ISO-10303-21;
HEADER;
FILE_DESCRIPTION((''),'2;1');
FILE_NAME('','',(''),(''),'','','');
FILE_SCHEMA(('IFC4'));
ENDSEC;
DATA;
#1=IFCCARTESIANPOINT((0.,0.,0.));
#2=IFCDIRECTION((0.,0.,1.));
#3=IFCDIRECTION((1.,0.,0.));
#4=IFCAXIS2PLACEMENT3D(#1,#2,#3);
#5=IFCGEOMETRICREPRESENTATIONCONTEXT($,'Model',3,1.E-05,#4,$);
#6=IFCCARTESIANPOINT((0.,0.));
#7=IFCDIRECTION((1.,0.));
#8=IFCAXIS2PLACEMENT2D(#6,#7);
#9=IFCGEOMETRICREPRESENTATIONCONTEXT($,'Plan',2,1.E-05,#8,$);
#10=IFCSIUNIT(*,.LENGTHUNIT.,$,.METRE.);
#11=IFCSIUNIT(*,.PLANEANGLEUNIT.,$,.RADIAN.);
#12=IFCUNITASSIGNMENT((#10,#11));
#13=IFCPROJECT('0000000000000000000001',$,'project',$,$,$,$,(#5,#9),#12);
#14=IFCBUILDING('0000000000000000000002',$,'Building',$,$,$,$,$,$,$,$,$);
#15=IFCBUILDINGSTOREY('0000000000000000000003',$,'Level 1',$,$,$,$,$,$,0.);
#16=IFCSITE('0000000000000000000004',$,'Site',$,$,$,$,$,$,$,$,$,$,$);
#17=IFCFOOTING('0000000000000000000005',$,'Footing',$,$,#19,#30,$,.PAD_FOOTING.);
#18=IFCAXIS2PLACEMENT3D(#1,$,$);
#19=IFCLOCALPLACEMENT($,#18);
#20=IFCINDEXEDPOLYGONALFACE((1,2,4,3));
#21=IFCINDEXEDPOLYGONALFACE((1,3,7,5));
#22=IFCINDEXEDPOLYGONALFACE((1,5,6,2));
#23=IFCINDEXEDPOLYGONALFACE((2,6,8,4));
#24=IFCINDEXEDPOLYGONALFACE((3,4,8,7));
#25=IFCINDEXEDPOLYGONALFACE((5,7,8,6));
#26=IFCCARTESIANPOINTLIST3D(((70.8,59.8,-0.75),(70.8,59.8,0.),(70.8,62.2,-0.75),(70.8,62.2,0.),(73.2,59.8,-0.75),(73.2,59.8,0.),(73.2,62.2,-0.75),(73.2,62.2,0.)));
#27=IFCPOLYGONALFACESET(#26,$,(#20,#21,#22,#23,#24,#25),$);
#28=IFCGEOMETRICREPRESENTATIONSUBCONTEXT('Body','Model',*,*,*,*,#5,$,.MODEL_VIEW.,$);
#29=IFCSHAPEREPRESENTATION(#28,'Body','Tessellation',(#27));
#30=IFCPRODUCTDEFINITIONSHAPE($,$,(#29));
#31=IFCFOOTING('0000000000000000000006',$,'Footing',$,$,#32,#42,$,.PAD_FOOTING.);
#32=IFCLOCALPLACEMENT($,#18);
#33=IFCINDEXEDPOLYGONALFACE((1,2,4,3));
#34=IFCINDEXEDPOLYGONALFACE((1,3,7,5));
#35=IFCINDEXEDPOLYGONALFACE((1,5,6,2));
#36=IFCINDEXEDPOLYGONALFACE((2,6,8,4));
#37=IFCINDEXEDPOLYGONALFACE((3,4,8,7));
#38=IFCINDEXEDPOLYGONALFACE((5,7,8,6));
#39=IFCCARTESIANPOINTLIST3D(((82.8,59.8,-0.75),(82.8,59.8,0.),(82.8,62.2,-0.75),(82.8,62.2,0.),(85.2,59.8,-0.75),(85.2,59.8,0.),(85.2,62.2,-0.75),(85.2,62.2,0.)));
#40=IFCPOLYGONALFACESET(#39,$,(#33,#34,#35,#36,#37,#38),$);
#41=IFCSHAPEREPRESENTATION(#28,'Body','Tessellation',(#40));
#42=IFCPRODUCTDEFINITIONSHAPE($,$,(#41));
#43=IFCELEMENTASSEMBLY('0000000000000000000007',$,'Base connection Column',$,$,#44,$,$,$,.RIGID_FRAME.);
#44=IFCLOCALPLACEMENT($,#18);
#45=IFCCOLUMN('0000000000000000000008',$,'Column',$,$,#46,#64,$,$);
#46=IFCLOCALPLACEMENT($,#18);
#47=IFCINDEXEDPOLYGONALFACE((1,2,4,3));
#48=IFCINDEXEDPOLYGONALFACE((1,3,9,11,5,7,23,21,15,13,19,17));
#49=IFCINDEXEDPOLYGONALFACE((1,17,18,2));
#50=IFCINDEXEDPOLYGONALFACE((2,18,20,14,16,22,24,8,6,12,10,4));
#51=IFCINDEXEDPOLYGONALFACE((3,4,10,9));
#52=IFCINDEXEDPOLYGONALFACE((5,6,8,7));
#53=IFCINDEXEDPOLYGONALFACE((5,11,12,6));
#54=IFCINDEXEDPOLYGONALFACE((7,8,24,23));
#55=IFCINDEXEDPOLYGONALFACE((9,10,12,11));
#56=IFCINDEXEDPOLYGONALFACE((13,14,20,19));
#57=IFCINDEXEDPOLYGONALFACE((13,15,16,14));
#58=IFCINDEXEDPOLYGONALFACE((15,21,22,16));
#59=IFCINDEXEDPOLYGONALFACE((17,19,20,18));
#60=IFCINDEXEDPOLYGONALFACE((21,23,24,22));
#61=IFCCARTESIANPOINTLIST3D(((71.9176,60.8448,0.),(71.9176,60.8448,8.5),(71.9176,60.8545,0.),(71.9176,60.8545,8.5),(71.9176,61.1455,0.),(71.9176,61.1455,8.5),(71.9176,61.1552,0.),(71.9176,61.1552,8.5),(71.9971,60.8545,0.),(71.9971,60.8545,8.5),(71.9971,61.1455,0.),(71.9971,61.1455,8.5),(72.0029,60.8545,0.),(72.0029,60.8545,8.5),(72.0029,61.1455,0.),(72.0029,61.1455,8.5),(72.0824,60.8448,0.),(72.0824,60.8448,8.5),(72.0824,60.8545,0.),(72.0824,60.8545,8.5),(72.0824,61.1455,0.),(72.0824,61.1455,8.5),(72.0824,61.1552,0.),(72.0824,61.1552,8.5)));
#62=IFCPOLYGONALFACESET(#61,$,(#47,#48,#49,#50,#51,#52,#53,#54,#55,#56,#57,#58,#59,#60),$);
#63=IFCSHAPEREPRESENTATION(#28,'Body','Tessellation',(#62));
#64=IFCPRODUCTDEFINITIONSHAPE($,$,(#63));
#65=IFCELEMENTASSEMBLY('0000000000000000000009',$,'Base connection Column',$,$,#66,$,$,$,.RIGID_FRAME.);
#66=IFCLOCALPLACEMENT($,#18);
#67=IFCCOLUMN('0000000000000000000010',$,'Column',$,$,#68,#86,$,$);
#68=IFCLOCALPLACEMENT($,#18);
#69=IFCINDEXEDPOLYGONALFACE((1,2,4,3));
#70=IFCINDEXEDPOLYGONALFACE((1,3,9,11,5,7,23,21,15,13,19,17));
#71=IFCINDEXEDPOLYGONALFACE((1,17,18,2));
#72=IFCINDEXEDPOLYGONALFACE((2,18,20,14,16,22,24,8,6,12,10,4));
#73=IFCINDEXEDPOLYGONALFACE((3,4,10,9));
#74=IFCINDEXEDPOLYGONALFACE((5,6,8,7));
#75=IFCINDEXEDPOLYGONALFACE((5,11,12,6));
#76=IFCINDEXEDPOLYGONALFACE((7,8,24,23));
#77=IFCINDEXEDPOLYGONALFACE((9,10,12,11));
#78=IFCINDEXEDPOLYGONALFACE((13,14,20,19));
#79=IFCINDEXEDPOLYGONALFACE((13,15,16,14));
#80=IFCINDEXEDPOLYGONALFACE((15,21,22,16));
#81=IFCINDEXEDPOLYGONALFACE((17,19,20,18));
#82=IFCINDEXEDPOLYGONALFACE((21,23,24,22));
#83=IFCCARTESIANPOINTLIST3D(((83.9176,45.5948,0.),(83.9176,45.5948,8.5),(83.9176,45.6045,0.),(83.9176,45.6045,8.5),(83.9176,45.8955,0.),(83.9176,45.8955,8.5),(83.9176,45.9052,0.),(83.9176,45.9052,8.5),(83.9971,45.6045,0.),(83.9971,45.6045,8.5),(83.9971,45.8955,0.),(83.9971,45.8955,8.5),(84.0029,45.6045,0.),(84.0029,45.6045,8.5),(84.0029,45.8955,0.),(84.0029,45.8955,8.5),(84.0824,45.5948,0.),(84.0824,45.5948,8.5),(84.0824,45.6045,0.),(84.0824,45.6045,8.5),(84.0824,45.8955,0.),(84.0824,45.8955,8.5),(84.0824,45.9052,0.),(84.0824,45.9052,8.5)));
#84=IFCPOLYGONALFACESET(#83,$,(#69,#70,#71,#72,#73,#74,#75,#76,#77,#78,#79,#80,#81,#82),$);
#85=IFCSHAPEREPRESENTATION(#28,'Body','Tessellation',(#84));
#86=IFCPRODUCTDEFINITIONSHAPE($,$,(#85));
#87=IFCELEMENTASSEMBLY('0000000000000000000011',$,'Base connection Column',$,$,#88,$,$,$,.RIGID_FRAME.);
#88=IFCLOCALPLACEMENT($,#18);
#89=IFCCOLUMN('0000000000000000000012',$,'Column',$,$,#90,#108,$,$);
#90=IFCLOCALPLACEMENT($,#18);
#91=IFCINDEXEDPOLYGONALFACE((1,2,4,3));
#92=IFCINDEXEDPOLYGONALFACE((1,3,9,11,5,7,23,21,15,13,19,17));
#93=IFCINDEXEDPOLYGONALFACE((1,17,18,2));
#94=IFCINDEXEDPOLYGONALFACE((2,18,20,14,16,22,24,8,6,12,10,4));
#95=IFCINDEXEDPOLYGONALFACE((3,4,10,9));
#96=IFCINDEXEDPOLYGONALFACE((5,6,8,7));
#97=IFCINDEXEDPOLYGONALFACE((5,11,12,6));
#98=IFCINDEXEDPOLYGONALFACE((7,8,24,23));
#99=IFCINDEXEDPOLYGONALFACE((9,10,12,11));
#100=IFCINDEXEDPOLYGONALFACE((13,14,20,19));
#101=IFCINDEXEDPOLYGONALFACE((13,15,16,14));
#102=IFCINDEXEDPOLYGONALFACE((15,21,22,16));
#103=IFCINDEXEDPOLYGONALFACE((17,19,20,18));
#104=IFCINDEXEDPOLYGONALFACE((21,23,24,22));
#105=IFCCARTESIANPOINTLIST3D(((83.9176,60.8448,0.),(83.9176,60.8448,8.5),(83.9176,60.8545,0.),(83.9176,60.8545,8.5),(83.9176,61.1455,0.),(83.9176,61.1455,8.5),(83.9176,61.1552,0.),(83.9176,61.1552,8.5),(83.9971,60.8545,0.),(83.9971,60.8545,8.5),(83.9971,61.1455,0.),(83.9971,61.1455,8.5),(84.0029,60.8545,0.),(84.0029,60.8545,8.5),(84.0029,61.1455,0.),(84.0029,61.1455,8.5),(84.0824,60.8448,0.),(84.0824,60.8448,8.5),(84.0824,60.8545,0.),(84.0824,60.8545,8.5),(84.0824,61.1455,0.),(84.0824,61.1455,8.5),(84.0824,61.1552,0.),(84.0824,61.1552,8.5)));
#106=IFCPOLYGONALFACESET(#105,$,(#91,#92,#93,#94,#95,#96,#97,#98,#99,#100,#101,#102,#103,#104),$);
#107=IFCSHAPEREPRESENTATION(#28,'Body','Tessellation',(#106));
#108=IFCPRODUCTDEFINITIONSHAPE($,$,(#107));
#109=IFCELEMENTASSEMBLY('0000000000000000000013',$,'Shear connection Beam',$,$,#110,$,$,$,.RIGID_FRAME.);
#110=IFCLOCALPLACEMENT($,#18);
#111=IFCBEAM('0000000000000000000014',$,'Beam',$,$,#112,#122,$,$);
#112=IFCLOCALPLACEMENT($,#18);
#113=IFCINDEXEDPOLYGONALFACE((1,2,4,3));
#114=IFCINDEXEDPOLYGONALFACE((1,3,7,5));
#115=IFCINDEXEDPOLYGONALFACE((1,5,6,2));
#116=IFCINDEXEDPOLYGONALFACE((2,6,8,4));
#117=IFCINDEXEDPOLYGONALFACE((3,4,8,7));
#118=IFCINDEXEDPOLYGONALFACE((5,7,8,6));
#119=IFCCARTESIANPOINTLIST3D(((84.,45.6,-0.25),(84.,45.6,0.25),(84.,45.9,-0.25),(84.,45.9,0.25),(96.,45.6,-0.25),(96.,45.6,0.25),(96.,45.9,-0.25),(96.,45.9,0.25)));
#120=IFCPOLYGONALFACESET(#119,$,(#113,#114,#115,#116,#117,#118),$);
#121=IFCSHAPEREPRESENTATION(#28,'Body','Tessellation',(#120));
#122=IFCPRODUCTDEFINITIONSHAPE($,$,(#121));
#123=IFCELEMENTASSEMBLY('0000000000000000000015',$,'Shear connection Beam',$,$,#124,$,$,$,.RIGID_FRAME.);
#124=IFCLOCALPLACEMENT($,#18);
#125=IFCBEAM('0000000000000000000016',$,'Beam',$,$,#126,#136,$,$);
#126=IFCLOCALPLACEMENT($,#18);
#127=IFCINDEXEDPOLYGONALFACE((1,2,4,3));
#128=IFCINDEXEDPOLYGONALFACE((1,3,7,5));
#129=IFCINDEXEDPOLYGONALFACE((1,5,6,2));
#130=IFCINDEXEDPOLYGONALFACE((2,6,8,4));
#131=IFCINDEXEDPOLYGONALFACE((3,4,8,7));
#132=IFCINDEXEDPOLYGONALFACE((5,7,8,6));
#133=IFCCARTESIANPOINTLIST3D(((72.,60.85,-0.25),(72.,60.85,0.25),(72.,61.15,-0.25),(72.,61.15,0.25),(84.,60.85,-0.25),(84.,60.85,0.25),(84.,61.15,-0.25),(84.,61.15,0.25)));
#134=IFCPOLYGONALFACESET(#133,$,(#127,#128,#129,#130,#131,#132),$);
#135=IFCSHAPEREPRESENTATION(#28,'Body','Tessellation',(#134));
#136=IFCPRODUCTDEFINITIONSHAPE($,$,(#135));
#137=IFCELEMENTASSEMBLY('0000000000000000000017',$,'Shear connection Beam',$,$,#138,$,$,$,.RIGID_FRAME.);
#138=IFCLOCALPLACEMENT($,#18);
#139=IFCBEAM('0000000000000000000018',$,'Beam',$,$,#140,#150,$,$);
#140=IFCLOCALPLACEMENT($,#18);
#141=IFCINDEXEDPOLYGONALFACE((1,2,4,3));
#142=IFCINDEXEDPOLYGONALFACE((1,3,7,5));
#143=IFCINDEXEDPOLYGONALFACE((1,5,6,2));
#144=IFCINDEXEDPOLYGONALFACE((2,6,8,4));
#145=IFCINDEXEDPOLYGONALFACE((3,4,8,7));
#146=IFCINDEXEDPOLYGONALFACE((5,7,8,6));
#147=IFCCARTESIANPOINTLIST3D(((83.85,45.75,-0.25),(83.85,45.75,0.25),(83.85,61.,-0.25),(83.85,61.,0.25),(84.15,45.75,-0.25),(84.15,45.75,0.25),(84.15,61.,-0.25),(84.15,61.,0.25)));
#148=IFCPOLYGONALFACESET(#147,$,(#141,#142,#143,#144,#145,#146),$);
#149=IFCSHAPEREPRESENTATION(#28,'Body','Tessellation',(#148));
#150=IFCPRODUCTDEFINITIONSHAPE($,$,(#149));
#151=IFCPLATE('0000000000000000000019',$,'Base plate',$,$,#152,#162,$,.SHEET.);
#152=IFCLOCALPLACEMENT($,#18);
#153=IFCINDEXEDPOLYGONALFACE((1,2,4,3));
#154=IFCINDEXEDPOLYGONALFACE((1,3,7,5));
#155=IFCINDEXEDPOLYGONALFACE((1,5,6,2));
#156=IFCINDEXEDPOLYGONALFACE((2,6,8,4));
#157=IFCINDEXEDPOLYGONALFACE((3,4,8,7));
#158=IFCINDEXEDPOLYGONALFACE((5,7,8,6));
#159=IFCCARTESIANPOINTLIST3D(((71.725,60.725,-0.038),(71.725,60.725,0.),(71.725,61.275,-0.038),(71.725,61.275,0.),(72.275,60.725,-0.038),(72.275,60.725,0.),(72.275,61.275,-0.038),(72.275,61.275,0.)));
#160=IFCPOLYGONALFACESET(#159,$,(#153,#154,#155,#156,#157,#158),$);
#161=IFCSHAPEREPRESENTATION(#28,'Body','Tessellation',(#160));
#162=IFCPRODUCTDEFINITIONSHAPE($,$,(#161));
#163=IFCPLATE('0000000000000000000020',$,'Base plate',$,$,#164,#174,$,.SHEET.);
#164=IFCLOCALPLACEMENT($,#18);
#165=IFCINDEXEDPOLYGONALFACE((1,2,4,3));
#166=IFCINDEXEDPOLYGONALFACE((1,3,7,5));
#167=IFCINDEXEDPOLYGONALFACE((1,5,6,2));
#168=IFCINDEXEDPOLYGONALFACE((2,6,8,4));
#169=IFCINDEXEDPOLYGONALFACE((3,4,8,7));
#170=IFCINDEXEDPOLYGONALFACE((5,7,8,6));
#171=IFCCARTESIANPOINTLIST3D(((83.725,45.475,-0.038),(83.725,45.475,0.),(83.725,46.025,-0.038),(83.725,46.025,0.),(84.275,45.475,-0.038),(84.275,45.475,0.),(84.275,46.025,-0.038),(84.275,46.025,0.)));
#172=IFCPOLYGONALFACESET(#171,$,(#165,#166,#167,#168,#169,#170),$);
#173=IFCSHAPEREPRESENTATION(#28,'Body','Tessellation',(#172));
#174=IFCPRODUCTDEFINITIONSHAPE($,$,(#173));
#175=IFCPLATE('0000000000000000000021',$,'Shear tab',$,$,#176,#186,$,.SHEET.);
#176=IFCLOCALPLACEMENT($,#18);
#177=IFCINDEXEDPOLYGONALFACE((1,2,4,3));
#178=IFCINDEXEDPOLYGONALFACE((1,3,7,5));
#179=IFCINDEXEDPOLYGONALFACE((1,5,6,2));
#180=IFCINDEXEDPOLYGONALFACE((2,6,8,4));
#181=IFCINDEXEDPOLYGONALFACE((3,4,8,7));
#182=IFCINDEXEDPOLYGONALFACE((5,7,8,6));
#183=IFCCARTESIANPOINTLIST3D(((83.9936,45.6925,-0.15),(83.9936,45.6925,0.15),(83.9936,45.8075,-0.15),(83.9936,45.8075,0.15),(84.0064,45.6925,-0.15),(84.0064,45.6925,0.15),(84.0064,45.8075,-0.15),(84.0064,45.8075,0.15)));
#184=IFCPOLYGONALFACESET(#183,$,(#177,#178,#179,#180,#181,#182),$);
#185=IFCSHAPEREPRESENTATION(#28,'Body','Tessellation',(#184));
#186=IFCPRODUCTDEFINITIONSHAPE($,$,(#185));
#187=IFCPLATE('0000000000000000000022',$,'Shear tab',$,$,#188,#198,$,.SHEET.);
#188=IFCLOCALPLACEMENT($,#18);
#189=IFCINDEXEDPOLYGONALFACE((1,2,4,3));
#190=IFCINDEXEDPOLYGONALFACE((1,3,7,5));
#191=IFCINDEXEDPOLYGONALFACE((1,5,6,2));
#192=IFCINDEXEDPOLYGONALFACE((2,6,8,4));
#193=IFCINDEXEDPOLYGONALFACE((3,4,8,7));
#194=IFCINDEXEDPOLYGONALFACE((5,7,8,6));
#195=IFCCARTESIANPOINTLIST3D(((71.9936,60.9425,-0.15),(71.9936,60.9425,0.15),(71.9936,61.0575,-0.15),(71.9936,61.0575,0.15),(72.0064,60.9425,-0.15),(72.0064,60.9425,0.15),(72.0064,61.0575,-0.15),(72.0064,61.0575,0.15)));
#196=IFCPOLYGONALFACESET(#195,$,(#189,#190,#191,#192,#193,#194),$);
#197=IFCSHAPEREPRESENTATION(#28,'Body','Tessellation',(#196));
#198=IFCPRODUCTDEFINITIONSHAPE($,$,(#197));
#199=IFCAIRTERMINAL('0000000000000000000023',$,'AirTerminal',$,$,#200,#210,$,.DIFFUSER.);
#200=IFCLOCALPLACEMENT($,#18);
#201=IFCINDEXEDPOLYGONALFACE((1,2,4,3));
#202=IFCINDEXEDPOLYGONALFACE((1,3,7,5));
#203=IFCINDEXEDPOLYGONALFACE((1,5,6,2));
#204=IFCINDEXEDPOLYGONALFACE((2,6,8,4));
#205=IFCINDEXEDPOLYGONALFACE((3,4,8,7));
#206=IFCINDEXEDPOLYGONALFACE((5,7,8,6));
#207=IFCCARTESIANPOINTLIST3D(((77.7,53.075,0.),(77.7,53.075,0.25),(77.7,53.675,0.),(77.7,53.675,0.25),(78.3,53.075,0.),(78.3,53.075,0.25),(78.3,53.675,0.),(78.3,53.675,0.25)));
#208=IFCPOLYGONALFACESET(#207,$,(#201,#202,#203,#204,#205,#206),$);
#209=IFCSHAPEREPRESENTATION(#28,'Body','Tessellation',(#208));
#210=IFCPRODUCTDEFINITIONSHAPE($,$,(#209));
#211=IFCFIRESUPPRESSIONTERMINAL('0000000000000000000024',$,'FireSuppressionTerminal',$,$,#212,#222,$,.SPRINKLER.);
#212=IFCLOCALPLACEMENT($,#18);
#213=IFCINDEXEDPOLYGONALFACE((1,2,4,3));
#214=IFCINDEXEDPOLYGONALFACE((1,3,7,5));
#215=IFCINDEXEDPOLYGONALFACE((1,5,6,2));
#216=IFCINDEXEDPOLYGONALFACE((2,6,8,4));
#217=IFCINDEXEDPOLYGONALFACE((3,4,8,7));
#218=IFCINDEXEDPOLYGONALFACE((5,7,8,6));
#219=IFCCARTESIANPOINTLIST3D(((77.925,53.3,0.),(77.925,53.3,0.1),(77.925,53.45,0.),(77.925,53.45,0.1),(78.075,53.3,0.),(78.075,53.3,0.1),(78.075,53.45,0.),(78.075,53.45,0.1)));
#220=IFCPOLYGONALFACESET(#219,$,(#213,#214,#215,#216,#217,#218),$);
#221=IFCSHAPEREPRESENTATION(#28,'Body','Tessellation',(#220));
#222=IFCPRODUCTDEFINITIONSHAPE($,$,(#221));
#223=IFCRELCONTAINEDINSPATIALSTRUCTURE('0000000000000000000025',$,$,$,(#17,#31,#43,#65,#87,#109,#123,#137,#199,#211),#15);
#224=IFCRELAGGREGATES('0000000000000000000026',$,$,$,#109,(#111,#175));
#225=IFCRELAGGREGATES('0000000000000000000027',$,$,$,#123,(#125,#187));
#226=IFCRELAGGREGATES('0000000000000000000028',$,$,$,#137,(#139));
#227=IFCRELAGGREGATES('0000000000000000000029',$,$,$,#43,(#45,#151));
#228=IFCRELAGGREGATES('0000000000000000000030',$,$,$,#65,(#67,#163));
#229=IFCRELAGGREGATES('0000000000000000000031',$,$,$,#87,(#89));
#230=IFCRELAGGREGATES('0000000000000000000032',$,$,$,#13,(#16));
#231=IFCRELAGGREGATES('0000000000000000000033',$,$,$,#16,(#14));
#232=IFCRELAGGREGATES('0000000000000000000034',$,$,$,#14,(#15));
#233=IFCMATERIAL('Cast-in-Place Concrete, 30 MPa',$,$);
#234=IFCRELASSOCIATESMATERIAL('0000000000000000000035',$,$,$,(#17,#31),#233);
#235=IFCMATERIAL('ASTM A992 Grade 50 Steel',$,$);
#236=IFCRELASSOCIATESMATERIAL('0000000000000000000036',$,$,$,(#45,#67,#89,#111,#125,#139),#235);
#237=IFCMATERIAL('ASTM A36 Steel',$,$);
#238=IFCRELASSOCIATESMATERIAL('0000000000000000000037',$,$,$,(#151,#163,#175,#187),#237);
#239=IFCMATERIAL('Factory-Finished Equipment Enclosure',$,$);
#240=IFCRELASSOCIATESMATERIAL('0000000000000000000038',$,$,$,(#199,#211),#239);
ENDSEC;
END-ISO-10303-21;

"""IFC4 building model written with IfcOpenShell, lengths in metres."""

from ifc_helpers import new_model, si_unit, frame, origin_with_axes, origin_2d_with_axis, place, context, subcontext, project, spatial, rectangle, i_section, extrude, material, element, aggregate, save


model = new_model("IFC4")

# Units and contexts
model_context = context("Model", 3, precision=1e-05, world=origin_with_axes())
plan_context = context("Plan", 2, precision=1e-05, world=origin_2d_with_axis())
body_context = subcontext(model_context, "Body", "Model", "MODEL_VIEW")
ifc_project = project(units=[si_unit("LENGTHUNIT", "METRE"), si_unit("PLANEANGLEUNIT", "RADIAN")], contexts=[model_context, plan_context])

# Site, building, storey
site = spatial("IfcSite", under=ifc_project, Name="Site")
building = spatial("IfcBuilding", under=site, Name="Building")
storey = spatial("IfcBuildingStorey", under=building, Name="Level 1", Elevation=0.0)

# Footings
ifc_material_1 = material(Name="Cast-in-Place Concrete, 30 MPa")
for number, where, z_axis, x_axis, name in (
    (1, (72.0, 61.0, -0.75), (0.0, 0.0, 1.0), (1.0, 0.0, 0.0), "Footing"),
    (2, (84.0, 61.0, -0.75), (0.0, 0.0, 1.0), (1.0, 0.0, 0.0), "Footing"),
):
    element("IfcFooting", number, at=place(None, frame(where, z_axis=z_axis, x_axis=x_axis)), inside=storey, material=ifc_material_1, Name=name, PredefinedType="PAD_FOOTING", context=body_context, shape_type="SweptSolid", body=[
        extrude(rectangle(XDim=2.4, YDim=2.4, at=origin_2d_with_axis()), origin_with_axes(), (0.0, 0.0, 1.0), 0.75),
    ])

# Element assemblies, columns
assembly_1 = element("IfcElementAssembly", 3, inside=storey, Name="Base connection Column", PredefinedType="RIGID_FRAME")
ifc_material_2 = material(Name="ASTM A992 Grade 50 Steel")
column_1_placement = place(None, frame((72.0, 61.0, 0.0), z_axis=(0.0, 0.0, 1.0), x_axis=(1.0, 0.0, 0.0)))
column_1 = element("IfcColumn", 4, at=column_1_placement, material=ifc_material_2, Name="Column", context=body_context, shape_type="SweptSolid", body=[
    extrude(i_section(OverallWidth=0.1648, OverallDepth=0.3104, WebThickness=0.0058, FlangeThickness=0.0097, at=origin_2d_with_axis()), origin_with_axes(), (0.0, 0.0, 1.0), 8.5),
])
assembly_2 = element("IfcElementAssembly", 5, inside=storey, Name="Base connection Column", PredefinedType="RIGID_FRAME")
column_2_placement = place(None, frame((84.0, 45.75, 0.0), z_axis=(0.0, 0.0, 1.0), x_axis=(1.0, 0.0, 0.0)))
column_2 = element("IfcColumn", 6, at=column_2_placement, material=ifc_material_2, Name="Column", context=body_context, shape_type="SweptSolid", body=[
    extrude(i_section(OverallWidth=0.1648, OverallDepth=0.3104, WebThickness=0.0058, FlangeThickness=0.0097, at=origin_2d_with_axis()), origin_with_axes(), (0.0, 0.0, 1.0), 8.5),
])
assembly_3 = element("IfcElementAssembly", 7, inside=storey, Name="Base connection Column", PredefinedType="RIGID_FRAME")
column_3_placement = place(None, frame((84.0, 61.0, 0.0), z_axis=(0.0, 0.0, 1.0), x_axis=(1.0, 0.0, 0.0)))
column_3 = element("IfcColumn", 8, at=column_3_placement, material=ifc_material_2, Name="Column", context=body_context, shape_type="SweptSolid", body=[
    extrude(i_section(OverallWidth=0.1648, OverallDepth=0.3104, WebThickness=0.0058, FlangeThickness=0.0097, at=origin_2d_with_axis()), origin_with_axes(), (0.0, 0.0, 1.0), 8.5),
])

# Element assemblies, beams
assembly_4 = element("IfcElementAssembly", 9, inside=storey, Name="Shear connection Beam", PredefinedType="RIGID_FRAME")
beam_1_placement = place(None, frame((84.0, 45.75, 0.0), z_axis=(1.0, 0.0, 0.0), x_axis=(0.0, 1.0, 0.0)))
beam_1 = element("IfcBeam", 10, at=beam_1_placement, material=ifc_material_2, Name="Beam", context=body_context, shape_type="SweptSolid", body=[
    extrude(rectangle(XDim=0.3, YDim=0.5, at=origin_2d_with_axis()), origin_with_axes(), (0.0, 0.0, 1.0), 12.0),
])
assembly_5 = element("IfcElementAssembly", 11, inside=storey, Name="Shear connection Beam", PredefinedType="RIGID_FRAME")
beam_2_placement = place(None, frame((72.0, 61.0, 0.0), z_axis=(1.0, 0.0, 0.0), x_axis=(0.0, 1.0, 0.0)))
beam_2 = element("IfcBeam", 12, at=beam_2_placement, material=ifc_material_2, Name="Beam", context=body_context, shape_type="SweptSolid", body=[
    extrude(rectangle(XDim=0.3, YDim=0.5, at=origin_2d_with_axis()), origin_with_axes(), (0.0, 0.0, 1.0), 12.0),
])
assembly_6 = element("IfcElementAssembly", 13, inside=storey, Name="Shear connection Beam", PredefinedType="RIGID_FRAME")
beam_3_placement = place(None, frame((84.0, 45.75, 0.0), z_axis=(0.0, 1.0, 0.0), x_axis=(-1.0, 0.0, 0.0)))
beam_3 = element("IfcBeam", 14, at=beam_3_placement, material=ifc_material_2, Name="Beam", context=body_context, shape_type="SweptSolid", body=[
    extrude(rectangle(XDim=0.3, YDim=0.5, at=origin_2d_with_axis()), origin_with_axes(), (0.0, 0.0, 1.0), 15.25),
])

# Plates
ifc_material_3 = material(Name="ASTM A36 Steel")
plate_1_placement = place(None, frame((72.0, 61.0, -0.038), z_axis=(0.0, 0.0, 1.0), x_axis=(1.0, 0.0, 0.0)))
plate_1 = element("IfcPlate", 15, at=plate_1_placement, material=ifc_material_3, Name="Base plate", PredefinedType="SHEET", context=body_context, shape_type="SweptSolid", body=[
    extrude(rectangle(XDim=0.55, YDim=0.55, at=origin_2d_with_axis()), origin_with_axes(), (0.0, 0.0, 1.0), 0.038),
])
plate_2_placement = place(None, frame((84.0, 45.75, -0.038), z_axis=(0.0, 0.0, 1.0), x_axis=(1.0, 0.0, 0.0)))
plate_2 = element("IfcPlate", 16, at=plate_2_placement, material=ifc_material_3, Name="Base plate", PredefinedType="SHEET", context=body_context, shape_type="SweptSolid", body=[
    extrude(rectangle(XDim=0.55, YDim=0.55, at=origin_2d_with_axis()), origin_with_axes(), (0.0, 0.0, 1.0), 0.038),
])
plate_3_placement = place(None, frame((84.0, 45.75, -0.15), z_axis=(0.0, 0.0, 1.0), x_axis=(1.0, 0.0, 0.0)))
plate_3 = element("IfcPlate", 17, at=plate_3_placement, material=ifc_material_3, Name="Shear tab", PredefinedType="SHEET", context=body_context, shape_type="SweptSolid", body=[
    extrude(rectangle(XDim=0.0127, YDim=0.115, at=origin_2d_with_axis()), origin_with_axes(), (0.0, 0.0, 1.0), 0.3),
])
aggregate(assembly_4, [beam_1, plate_3])
plate_4_placement = place(None, frame((72.0, 61.0, -0.15), z_axis=(0.0, 0.0, 1.0), x_axis=(1.0, 0.0, 0.0)))
plate_4 = element("IfcPlate", 18, at=plate_4_placement, material=ifc_material_3, Name="Shear tab", PredefinedType="SHEET", context=body_context, shape_type="SweptSolid", body=[
    extrude(rectangle(XDim=0.0127, YDim=0.115, at=origin_2d_with_axis()), origin_with_axes(), (0.0, 0.0, 1.0), 0.3),
])
aggregate(assembly_5, [beam_2, plate_4])
aggregate(assembly_6, [beam_3])

# Air terminal
ifc_material_4 = material(Name="Factory-Finished Equipment Enclosure")
air_terminal_placement = place(None, frame((78.0, 53.375, 0.0), z_axis=(0.0, 0.0, 1.0), x_axis=(1.0, 0.0, 0.0)))
element("IfcAirTerminal", 19, at=air_terminal_placement, inside=storey, material=ifc_material_4, Name="AirTerminal", PredefinedType="DIFFUSER", context=body_context, shape_type="SweptSolid", body=[
    extrude(rectangle(XDim=0.6, YDim=0.6, at=origin_2d_with_axis()), origin_with_axes(), (0.0, 0.0, 1.0), 0.25),
])

# Fire suppression terminal
fire_suppression_terminal_placement = place(None, frame((78.0, 53.375, 0.0), z_axis=(0.0, 0.0, 1.0), x_axis=(1.0, 0.0, 0.0)))
element("IfcFireSuppressionTerminal", 20, at=fire_suppression_terminal_placement, inside=storey, material=ifc_material_4, Name="FireSuppressionTerminal", PredefinedType="SPRINKLER", context=body_context, shape_type="SweptSolid", body=[
    extrude(rectangle(XDim=0.15, YDim=0.15, at=origin_2d_with_axis()), origin_with_axes(), (0.0, 0.0, 1.0), 0.1),
])

aggregate(assembly_1, [column_1, plate_1])
aggregate(assembly_2, [column_2, plate_2])
aggregate(assembly_3, [column_3])

save(model, "model.ifc")
